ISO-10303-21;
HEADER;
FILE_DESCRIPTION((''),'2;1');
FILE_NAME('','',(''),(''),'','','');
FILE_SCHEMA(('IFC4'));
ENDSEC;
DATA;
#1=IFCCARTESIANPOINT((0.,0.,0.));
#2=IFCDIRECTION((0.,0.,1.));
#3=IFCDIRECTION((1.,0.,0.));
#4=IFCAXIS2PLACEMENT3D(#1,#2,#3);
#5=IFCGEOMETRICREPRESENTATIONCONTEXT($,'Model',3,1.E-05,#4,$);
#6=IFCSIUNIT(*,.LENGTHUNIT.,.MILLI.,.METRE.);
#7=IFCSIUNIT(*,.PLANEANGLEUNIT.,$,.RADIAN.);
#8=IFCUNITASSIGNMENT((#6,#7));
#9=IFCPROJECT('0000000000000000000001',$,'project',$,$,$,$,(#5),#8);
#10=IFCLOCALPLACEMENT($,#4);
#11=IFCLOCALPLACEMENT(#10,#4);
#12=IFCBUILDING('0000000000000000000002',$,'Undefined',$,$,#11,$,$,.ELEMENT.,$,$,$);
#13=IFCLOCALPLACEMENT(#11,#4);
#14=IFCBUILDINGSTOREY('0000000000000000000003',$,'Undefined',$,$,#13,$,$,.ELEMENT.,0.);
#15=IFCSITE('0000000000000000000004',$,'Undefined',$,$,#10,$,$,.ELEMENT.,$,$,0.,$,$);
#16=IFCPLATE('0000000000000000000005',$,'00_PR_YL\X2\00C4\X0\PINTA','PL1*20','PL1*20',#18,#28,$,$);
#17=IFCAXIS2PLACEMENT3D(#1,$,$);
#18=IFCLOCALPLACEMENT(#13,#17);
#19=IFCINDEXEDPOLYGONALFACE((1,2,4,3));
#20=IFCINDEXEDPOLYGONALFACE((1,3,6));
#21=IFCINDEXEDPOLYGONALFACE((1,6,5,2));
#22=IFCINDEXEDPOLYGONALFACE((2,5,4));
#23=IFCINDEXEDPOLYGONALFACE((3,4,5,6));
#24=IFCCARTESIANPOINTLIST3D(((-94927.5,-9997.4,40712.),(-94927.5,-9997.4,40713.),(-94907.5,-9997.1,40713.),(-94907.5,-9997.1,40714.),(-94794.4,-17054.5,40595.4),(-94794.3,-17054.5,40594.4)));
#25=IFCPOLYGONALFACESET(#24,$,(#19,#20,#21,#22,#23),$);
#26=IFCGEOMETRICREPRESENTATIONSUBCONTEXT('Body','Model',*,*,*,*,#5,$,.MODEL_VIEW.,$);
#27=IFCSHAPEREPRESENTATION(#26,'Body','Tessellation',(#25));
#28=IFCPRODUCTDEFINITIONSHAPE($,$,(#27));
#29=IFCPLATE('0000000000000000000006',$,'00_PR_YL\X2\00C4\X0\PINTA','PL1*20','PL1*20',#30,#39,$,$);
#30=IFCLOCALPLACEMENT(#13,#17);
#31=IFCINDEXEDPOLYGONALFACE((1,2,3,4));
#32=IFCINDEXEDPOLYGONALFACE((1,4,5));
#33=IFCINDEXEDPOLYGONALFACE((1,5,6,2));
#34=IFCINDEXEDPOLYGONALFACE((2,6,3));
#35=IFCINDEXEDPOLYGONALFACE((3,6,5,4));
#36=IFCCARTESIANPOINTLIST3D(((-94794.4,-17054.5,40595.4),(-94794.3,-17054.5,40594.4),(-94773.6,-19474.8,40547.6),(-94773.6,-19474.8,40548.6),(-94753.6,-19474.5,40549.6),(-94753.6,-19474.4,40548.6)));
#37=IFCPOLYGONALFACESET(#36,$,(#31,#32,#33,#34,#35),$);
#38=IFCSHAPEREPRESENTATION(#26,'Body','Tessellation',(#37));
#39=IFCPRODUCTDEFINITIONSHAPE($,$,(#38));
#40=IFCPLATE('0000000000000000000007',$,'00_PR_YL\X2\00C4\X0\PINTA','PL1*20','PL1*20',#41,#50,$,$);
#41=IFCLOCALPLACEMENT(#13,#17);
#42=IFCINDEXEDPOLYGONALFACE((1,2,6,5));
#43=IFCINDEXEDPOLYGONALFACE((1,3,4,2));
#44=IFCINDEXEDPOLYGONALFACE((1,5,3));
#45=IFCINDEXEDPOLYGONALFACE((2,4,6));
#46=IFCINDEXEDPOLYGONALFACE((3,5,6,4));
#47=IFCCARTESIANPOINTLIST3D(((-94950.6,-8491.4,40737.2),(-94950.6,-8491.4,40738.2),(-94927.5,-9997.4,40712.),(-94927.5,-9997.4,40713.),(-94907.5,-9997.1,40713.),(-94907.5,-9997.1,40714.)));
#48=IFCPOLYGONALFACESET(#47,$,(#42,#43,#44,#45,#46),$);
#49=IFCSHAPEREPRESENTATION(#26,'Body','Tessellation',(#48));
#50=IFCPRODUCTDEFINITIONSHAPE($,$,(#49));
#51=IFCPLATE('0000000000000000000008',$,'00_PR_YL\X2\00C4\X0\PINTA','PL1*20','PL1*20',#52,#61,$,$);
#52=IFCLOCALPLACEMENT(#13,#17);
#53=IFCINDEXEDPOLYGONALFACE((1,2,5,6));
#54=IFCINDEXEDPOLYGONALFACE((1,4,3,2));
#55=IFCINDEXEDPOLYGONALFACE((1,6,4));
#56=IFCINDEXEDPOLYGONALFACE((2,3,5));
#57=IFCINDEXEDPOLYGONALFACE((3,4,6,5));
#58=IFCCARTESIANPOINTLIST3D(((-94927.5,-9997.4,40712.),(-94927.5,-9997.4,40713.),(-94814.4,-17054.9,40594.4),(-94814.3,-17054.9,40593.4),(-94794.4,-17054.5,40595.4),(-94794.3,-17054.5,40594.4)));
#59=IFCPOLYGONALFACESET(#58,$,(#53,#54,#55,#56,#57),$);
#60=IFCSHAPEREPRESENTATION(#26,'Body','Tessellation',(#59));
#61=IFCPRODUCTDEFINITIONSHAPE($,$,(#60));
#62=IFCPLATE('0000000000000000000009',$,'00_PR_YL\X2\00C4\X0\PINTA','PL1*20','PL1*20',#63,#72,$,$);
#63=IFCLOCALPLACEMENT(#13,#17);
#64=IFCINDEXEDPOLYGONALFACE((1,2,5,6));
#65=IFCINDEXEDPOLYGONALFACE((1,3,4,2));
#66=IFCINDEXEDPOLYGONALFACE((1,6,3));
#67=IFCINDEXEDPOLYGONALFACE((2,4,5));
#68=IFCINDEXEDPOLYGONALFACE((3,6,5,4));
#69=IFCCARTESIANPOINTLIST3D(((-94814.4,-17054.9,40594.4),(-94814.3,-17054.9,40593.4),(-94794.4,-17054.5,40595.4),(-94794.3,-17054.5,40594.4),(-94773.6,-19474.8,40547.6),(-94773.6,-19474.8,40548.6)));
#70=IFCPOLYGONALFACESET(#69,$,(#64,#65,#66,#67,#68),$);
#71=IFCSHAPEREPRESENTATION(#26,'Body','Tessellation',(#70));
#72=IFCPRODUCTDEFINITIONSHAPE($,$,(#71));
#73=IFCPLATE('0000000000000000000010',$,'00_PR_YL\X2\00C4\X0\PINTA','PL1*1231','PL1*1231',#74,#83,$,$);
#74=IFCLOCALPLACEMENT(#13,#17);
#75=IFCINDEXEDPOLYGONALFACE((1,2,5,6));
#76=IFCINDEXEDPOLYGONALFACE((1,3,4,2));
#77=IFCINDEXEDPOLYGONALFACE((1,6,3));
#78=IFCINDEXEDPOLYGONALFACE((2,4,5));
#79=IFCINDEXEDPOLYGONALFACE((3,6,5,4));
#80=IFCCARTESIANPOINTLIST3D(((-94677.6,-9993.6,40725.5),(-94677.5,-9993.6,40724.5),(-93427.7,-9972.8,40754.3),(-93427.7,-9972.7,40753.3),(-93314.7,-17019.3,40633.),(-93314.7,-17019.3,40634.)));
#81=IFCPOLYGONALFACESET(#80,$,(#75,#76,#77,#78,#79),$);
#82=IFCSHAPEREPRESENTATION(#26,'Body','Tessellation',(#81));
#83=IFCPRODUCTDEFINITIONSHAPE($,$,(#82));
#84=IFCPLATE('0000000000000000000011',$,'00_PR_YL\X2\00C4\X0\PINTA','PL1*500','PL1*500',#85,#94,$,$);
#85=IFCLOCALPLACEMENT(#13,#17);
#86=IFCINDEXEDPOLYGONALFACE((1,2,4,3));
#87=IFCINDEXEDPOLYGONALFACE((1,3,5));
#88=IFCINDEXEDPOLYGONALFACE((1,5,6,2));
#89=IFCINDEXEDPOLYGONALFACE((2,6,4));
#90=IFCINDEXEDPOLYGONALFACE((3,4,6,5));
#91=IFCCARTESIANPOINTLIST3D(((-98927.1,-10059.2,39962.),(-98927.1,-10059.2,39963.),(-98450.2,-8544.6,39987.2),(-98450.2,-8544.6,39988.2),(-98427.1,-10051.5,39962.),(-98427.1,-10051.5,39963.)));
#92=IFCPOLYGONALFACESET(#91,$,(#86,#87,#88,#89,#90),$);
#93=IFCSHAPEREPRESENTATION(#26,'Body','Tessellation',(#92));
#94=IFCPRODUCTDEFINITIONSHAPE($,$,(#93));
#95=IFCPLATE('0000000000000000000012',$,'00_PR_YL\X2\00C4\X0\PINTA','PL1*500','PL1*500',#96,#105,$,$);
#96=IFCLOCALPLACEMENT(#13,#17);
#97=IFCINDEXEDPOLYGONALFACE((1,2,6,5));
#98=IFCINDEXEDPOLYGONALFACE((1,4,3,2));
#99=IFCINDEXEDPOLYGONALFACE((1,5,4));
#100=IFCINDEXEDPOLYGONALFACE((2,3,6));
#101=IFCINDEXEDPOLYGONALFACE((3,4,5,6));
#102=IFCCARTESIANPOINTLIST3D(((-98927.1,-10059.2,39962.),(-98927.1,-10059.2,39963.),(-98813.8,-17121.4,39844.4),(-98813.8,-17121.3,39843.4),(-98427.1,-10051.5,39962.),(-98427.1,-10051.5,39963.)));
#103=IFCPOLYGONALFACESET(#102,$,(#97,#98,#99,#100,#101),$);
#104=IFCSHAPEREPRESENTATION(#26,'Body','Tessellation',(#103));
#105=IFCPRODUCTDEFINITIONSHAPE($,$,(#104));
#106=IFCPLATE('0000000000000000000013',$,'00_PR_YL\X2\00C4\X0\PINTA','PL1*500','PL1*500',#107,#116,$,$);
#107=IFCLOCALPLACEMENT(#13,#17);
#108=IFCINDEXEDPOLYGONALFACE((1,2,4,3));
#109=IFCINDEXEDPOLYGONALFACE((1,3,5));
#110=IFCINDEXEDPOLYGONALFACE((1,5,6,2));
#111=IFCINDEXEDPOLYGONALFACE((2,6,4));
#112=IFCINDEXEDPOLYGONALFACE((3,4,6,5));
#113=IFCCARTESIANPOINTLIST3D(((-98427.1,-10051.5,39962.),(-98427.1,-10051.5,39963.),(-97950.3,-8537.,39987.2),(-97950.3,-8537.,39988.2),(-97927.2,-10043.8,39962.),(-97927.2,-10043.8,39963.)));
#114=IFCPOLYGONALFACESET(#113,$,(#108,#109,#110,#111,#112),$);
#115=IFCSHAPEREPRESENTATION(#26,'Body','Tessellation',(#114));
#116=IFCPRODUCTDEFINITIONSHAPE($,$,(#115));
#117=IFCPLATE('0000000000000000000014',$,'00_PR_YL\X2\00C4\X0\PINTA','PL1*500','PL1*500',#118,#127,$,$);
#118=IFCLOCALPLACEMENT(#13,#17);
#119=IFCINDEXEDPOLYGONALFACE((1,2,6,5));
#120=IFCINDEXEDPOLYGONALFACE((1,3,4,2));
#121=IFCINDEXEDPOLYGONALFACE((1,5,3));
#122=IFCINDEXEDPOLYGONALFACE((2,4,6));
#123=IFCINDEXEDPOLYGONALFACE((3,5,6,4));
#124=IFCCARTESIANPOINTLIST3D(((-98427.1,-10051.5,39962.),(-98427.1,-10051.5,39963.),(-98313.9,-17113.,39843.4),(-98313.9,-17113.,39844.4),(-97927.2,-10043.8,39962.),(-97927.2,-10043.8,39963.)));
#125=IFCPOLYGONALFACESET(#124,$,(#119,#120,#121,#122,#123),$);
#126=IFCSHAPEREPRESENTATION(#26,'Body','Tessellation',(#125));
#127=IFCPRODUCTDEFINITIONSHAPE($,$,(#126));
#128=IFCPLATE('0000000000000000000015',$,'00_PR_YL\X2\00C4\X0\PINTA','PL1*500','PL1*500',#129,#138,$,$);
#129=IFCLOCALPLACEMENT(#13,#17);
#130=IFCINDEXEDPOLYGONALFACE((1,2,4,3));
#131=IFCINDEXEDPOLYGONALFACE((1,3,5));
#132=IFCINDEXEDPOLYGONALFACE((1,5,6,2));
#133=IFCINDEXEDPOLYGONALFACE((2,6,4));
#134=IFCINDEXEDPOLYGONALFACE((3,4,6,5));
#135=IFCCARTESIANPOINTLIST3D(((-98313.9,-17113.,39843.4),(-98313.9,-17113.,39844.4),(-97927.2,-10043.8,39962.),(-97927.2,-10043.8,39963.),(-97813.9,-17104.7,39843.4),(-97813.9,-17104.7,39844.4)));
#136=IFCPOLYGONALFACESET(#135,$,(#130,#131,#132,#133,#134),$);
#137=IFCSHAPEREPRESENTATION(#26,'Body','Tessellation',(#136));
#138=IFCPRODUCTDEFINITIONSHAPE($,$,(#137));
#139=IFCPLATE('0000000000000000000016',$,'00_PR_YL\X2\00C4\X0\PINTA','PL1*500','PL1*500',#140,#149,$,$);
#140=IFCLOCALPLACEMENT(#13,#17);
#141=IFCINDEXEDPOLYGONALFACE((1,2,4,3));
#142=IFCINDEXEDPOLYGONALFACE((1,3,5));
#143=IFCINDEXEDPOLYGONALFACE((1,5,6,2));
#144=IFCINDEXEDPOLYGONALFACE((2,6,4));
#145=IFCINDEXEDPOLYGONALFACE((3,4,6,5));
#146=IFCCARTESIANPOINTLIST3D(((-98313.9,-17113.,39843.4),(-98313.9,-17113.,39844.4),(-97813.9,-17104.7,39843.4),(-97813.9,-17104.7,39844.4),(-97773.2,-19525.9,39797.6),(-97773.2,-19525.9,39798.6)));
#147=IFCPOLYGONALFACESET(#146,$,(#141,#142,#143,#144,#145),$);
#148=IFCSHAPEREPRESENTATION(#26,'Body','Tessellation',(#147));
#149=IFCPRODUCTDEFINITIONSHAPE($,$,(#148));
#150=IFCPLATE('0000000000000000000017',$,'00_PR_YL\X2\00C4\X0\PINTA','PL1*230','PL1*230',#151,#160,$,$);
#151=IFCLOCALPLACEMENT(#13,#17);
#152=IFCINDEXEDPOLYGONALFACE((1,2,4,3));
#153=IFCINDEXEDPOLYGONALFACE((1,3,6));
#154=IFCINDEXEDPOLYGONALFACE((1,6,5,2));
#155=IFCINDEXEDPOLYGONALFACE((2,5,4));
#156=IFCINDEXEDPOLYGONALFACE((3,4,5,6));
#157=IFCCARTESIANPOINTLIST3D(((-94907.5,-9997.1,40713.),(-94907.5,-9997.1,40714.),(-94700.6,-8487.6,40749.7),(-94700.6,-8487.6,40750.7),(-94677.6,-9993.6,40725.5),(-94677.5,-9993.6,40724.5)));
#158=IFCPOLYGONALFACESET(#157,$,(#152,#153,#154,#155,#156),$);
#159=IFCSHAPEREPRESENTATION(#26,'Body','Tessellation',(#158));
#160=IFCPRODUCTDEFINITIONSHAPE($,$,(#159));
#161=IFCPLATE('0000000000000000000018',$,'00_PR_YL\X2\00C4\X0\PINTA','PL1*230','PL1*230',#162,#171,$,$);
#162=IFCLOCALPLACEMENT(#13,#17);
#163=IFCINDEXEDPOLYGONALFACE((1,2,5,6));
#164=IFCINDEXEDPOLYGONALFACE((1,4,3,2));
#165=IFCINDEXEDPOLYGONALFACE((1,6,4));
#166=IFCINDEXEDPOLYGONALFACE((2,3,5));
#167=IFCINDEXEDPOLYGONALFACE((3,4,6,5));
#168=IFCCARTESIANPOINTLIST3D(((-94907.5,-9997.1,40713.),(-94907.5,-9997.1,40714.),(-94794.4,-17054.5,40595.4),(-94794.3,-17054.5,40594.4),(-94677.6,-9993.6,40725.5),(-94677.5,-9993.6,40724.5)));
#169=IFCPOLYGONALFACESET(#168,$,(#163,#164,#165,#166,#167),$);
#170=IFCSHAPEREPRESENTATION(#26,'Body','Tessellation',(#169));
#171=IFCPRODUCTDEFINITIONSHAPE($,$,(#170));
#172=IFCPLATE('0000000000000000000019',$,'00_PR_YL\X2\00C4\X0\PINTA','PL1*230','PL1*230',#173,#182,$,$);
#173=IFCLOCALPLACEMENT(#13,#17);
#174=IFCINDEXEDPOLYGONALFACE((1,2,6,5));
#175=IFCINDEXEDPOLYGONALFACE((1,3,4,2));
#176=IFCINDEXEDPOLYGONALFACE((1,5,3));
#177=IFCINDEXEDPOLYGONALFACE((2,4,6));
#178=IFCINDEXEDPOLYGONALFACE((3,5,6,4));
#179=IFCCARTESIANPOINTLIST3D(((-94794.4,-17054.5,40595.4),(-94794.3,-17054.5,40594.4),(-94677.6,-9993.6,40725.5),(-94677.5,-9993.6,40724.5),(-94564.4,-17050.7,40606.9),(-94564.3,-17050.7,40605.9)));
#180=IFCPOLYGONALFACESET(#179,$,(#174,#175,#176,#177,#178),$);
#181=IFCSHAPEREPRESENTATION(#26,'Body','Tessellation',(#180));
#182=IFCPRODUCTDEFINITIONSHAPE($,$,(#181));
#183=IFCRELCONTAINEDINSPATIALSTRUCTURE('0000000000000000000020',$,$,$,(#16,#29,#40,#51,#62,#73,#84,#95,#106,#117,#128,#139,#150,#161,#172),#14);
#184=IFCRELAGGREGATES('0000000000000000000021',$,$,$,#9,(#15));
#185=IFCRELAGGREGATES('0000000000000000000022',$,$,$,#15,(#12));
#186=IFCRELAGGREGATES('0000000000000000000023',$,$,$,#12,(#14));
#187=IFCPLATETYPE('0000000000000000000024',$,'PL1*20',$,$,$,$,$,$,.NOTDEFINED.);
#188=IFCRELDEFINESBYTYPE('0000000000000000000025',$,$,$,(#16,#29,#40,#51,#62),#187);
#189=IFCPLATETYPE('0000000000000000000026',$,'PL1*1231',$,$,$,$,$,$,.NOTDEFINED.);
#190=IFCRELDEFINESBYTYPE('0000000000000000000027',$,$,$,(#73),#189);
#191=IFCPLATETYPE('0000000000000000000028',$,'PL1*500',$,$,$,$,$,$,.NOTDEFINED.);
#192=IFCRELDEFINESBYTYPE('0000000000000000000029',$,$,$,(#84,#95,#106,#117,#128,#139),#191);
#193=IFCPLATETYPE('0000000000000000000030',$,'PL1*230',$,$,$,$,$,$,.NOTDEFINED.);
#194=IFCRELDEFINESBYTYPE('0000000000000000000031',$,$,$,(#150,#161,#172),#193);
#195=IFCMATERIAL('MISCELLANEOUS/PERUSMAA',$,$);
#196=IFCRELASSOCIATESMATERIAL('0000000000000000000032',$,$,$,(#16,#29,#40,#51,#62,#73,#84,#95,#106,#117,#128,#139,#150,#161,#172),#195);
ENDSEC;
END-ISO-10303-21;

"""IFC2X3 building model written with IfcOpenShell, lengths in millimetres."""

from ifc_helpers import new_model, si_unit, frame, origin_with_axes, place, context, subcontext, project, spatial, polyline, outline, extrude, material, type_object, element, save


model = new_model("IFC2X3")

# Units and contexts
model_context = context("Model", 3, precision=1e-05, world=origin_with_axes())
body_context = subcontext(model_context, "Body", "Model", "MODEL_VIEW")
ifc_project = project(units=[si_unit("LENGTHUNIT", "METRE", prefix="MILLI"), si_unit("PLANEANGLEUNIT", "RADIAN")], contexts=[model_context])

# Site, building, storey
site_placement = place(None, origin_with_axes())
site = spatial("IfcSite", under=ifc_project, at=site_placement, Name="Undefined", CompositionType="ELEMENT", RefElevation=0.0)
building_placement = place(site_placement, origin_with_axes())
building = spatial("IfcBuilding", under=site, at=building_placement, Name="Undefined", CompositionType="ELEMENT")
storey_placement = place(building_placement, origin_with_axes())
storey = spatial("IfcBuildingStorey", under=building, at=storey_placement, Name="Undefined", CompositionType="ELEMENT", Elevation=0.0)

# Plates
ifc_material = material(Name="MISCELLANEOUS/PERUSMAA")
plate_type_1 = type_object("IfcPlateType", Name="PL1*20", PredefinedType="NOTDEFINED")
plate_1_placement = place(storey_placement, frame((-94927.5, -9997.4, 40712.5), z_axis=(0.049665, 0.017582, -0.998611), x_axis=(0.998633, 0.015446, 0.049938)))
element("IfcPlate", 1, at=plate_1_placement, inside=storey, type_object=plate_type_1, material=ifc_material, Name="00_PR_YLÄPINTA", Description="PL1*20", ObjectType="PL1*20", context=body_context, shape_type="SweptSolid", body=[
    extrude(outline(polyline([(0.0, 0.0), (20.0, 0.0), (18.1, 7059.3), (0.0, 0.0)])), frame((0.0, 0.0, -0.5), z_axis=(0.0, 0.0, 1.0), x_axis=(1.0, 0.0, 0.0)), (0.0, 0.0, 1.0), 1.0),
])
plate_2_placement = place(storey_placement, frame((-94794.3, -17054.5, 40594.9), z_axis=(0.049601, 0.019701, -0.998575), x_axis=(0.016819, -0.99968, -0.018887)))
element("IfcPlate", 2, at=plate_2_placement, inside=storey, type_object=plate_type_1, material=ifc_material, Name="00_PR_YLÄPINTA", Description="PL1*20", ObjectType="PL1*20", context=body_context, shape_type="SweptSolid", body=[
    extrude(outline(polyline([(0.0, 0.0), (2420.7, 0.0), (2420.7, 20.0), (0.0, 0.0)])), frame((0.0, 0.0, -0.5), z_axis=(0.0, 0.0, 1.0), x_axis=(1.0, 0.0, 0.0)), (0.0, 0.0, 1.0), 1.0),
])
plate_3_placement = place(storey_placement, frame((-94907.5, -9997.1, 40713.5), z_axis=(0.049666, 0.017502, -0.998613), x_axis=(-0.998633, -0.015446, -0.049938)))
element("IfcPlate", 3, at=plate_3_placement, inside=storey, type_object=plate_type_1, material=ifc_material, Name="00_PR_YLÄPINTA", Description="PL1*20", ObjectType="PL1*20", context=body_context, shape_type="SweptSolid", body=[
    extrude(outline(polyline([(0.0, 0.0), (20.0, 0.0), (18.5, 1506.4), (0.0, 0.0)])), frame((0.0, 0.0, -0.5), z_axis=(0.0, 0.0, 1.0), x_axis=(1.0, 0.0, 0.0)), (0.0, 0.0, 1.0), 1.0),
])
plate_4_placement = place(storey_placement, frame((-94794.3, -17054.5, 40594.9), z_axis=(0.049645, 0.017582, -0.998612), x_axis=(-0.998615, -0.016587, -0.049937)))
element("IfcPlate", 4, at=plate_4_placement, inside=storey, type_object=plate_type_1, material=ifc_material, Name="00_PR_YLÄPINTA", Description="PL1*20", ObjectType="PL1*20", context=body_context, shape_type="SweptSolid", body=[
    extrude(outline(polyline([(0.0, 0.0), (20.0, 0.0), (10.1, 7059.3), (0.0, 0.0)])), frame((0.0, 0.0, -0.5), z_axis=(0.0, 0.0, 1.0), x_axis=(1.0, 0.0, 0.0)), (0.0, 0.0, 1.0), 1.0),
])
plate_5_placement = place(storey_placement, frame((-94814.3, -17054.9, 40593.9), z_axis=(0.049608, 0.019701, -0.998574), x_axis=(0.998615, 0.016587, 0.049937)))
element("IfcPlate", 5, at=plate_5_placement, inside=storey, type_object=plate_type_1, material=ifc_material, Name="00_PR_YLÄPINTA", Description="PL1*20", ObjectType="PL1*20", context=body_context, shape_type="SweptSolid", body=[
    extrude(outline(polyline([(0.0, 0.0), (20.0, 0.0), (-1.8, 2420.7), (0.0, 0.0)])), frame((0.0, 0.0, -0.5), z_axis=(0.0, 0.0, 1.0), x_axis=(1.0, 0.0, 0.0)), (0.0, 0.0, 1.0), 1.0),
])
plate_type_2 = type_object("IfcPlateType", Name="PL1*1231", PredefinedType="NOTDEFINED")
plate_6_placement = place(storey_placement, frame((-94677.6, -9993.6, 40725.0), z_axis=(0.022772, 0.017436, -0.999589), x_axis=(0.999595, 0.016658, 0.023063)))
element("IfcPlate", 6, at=plate_6_placement, inside=storey, type_object=plate_type_2, material=ifc_material, Name="00_PR_YLÄPINTA", Description="PL1*1231", ObjectType="PL1*1231", context=body_context, shape_type="SweptSolid", body=[
    extrude(outline(polyline([(0.0, 0.0), (1250.3, 0.0), (1243.1, 7048.5), (0.0, 0.0)])), frame((0.0, 0.0, -0.5), z_axis=(0.0, 0.0, 1.0), x_axis=(1.0, 0.0, 0.0)), (0.0, 0.0, 1.0), 1.0),
])
plate_type_3 = type_object("IfcPlateType", Name="PL1*500", PredefinedType="NOTDEFINED")
plate_7_placement = place(storey_placement, frame((-98927.1, -10059.2, 39962.5), z_axis=(-0.000259, 0.016748, -0.99986), x_axis=(0.300253, 0.953727, 0.015898)))
element("IfcPlate", 7, at=plate_7_placement, inside=storey, type_object=plate_type_3, material=ifc_material, Name="00_PR_YLÄPINTA", Description="PL1*500", ObjectType="PL1*500", context=body_context, shape_type="SweptSolid", body=[
    extrude(outline(polyline([(0.0, 0.0), (1588.2, 0.0), (157.5, 474.6), (0.0, 0.0)])), frame((0.0, 0.0, -0.5), z_axis=(0.0, 0.0, 1.0), x_axis=(1.0, 0.0, 0.0)), (0.0, 0.0, 1.0), 1.0),
])
plate_8_placement = place(storey_placement, frame((-98427.1, -10051.5, 39962.5), z_axis=(-0.000259, 0.016791, -0.999859), x_axis=(-0.054606, -0.998367, -0.016752)))
element("IfcPlate", 8, at=plate_8_placement, inside=storey, type_object=plate_type_3, material=ifc_material, Name="00_PR_YLÄPINTA", Description="PL1*500", ObjectType="PL1*500", context=body_context, shape_type="SweptSolid", body=[
    extrude(outline(polyline([(0.0, 0.0), (7081.4, 0.0), (35.0, 498.8), (0.0, 0.0)])), frame((0.0, 0.0, -0.5), z_axis=(0.0, 0.0, 1.0), x_axis=(1.0, 0.0, 0.0)), (0.0, 0.0, 1.0), 1.0),
])
plate_9_placement = place(storey_placement, frame((-98427.1, -10051.5, 39962.5), z_axis=(-0.000259, 0.01675, -0.99986), x_axis=(0.300277, 0.95372, 0.015899)))
element("IfcPlate", 9, at=plate_9_placement, inside=storey, type_object=plate_type_3, material=ifc_material, Name="00_PR_YLÄPINTA", Description="PL1*500", ObjectType="PL1*500", context=body_context, shape_type="SweptSolid", body=[
    extrude(outline(polyline([(0.0, 0.0), (1588.0, 0.0), (157.5, 474.6), (0.0, 0.0)])), frame((0.0, 0.0, -0.5), z_axis=(0.0, 0.0, 1.0), x_axis=(1.0, 0.0, 0.0)), (0.0, 0.0, 1.0), 1.0),
])
plate_10_placement = place(storey_placement, frame((-97927.2, -10043.8, 39962.5), z_axis=(-0.000259, 0.016793, -0.999859), x_axis=(-0.054612, -0.998367, -0.016754)))
element("IfcPlate", 10, at=plate_10_placement, inside=storey, type_object=plate_type_3, material=ifc_material, Name="00_PR_YLÄPINTA", Description="PL1*500", ObjectType="PL1*500", context=body_context, shape_type="SweptSolid", body=[
    extrude(outline(polyline([(0.0, 0.0), (7080.8, 0.0), (35.0, 498.8), (0.0, 0.0)])), frame((0.0, 0.0, -0.5), z_axis=(0.0, 0.0, 1.0), x_axis=(1.0, 0.0, 0.0)), (0.0, 0.0, 1.0), 1.0),
])
plate_11_placement = place(storey_placement, frame((-98313.9, -17113.0, 39843.9), z_axis=(-0.000279, 0.016794, -0.999859), x_axis=(0.054612, 0.998367, 0.016754)))
element("IfcPlate", 11, at=plate_11_placement, inside=storey, type_object=plate_type_3, material=ifc_material, Name="00_PR_YLÄPINTA", Description="PL1*500", ObjectType="PL1*500", context=body_context, shape_type="SweptSolid", body=[
    extrude(outline(polyline([(0.0, 0.0), (7080.8, 0.0), (35.6, 498.7), (0.0, 0.0)])), frame((0.0, 0.0, -0.5), z_axis=(0.0, 0.0, 1.0), x_axis=(1.0, 0.0, 0.0)), (0.0, 0.0, 1.0), 1.0),
])
plate_12_placement = place(storey_placement, frame((-98313.9, -17113.0, 39843.9), z_axis=(-0.000314, 0.018875, -0.999822), x_axis=(0.999862, 0.016621, 0.0)))
element("IfcPlate", 12, at=plate_12_placement, inside=storey, type_object=plate_type_3, material=ifc_material, Name="00_PR_YLÄPINTA", Description="PL1*500", ObjectType="PL1*500", context=body_context, shape_type="SweptSolid", body=[
    extrude(outline(polyline([(0.0, 0.0), (500.0, 0.0), (500.5, 2421.9), (0.0, 0.0)])), frame((0.0, 0.0, -0.5), z_axis=(0.0, 0.0, 1.0), x_axis=(1.0, 0.0, 0.0)), (0.0, 0.0, 1.0), 1.0),
])
plate_type_4 = type_object("IfcPlateType", Name="PL1*230", PredefinedType="NOTDEFINED")
plate_13_placement = place(storey_placement, frame((-94907.5, -9997.1, 40713.5), z_axis=(0.049666, 0.017502, -0.998613), x_axis=(0.135747, 0.99045, 0.024111)))
element("IfcPlate", 13, at=plate_13_placement, inside=storey, type_object=plate_type_4, material=ifc_material, Name="00_PR_YLÄPINTA", Description="PL1*230", ObjectType="PL1*230", context=body_context, shape_type="SweptSolid", body=[
    extrude(outline(polyline([(0.0, 0.0), (1524.1, 0.0), (35.0, 227.6), (0.0, 0.0)])), frame((0.0, 0.0, -0.5), z_axis=(0.0, 0.0, 1.0), x_axis=(1.0, 0.0, 0.0)), (0.0, 0.0, 1.0), 1.0),
])
plate_14_placement = place(storey_placement, frame((-94677.5, -9993.6, 40725.0), z_axis=(0.049665, 0.017582, -0.998611), x_axis=(-0.016536, -0.999694, -0.018424)))
element("IfcPlate", 14, at=plate_14_placement, inside=storey, type_object=plate_type_4, material=ifc_material, Name="00_PR_YLÄPINTA", Description="PL1*230", ObjectType="PL1*230", context=body_context, shape_type="SweptSolid", body=[
    extrude(outline(polyline([(0.0, 0.0), (7063.1, 0.0), (7.6, 230.2), (0.0, 0.0)])), frame((0.0, 0.0, -0.5), z_axis=(0.0, 0.0, 1.0), x_axis=(1.0, 0.0, 0.0)), (0.0, 0.0, 1.0), 1.0),
])
plate_15_placement = place(storey_placement, frame((-94794.3, -17054.5, 40594.9), z_axis=(0.049645, 0.017582, -0.998612), x_axis=(0.016536, 0.999694, 0.018424)))
element("IfcPlate", 15, at=plate_15_placement, inside=storey, type_object=plate_type_4, material=ifc_material, Name="00_PR_YLÄPINTA", Description="PL1*230", ObjectType="PL1*230", context=body_context, shape_type="SweptSolid", body=[
    extrude(outline(polyline([(0.0, 0.0), (7063.1, 0.0), (7.8, 230.2), (0.0, 0.0)])), frame((0.0, 0.0, -0.5), z_axis=(0.0, 0.0, 1.0), x_axis=(1.0, 0.0, 0.0)), (0.0, 0.0, 1.0), 1.0),
])

save(model, "model.ifc")
